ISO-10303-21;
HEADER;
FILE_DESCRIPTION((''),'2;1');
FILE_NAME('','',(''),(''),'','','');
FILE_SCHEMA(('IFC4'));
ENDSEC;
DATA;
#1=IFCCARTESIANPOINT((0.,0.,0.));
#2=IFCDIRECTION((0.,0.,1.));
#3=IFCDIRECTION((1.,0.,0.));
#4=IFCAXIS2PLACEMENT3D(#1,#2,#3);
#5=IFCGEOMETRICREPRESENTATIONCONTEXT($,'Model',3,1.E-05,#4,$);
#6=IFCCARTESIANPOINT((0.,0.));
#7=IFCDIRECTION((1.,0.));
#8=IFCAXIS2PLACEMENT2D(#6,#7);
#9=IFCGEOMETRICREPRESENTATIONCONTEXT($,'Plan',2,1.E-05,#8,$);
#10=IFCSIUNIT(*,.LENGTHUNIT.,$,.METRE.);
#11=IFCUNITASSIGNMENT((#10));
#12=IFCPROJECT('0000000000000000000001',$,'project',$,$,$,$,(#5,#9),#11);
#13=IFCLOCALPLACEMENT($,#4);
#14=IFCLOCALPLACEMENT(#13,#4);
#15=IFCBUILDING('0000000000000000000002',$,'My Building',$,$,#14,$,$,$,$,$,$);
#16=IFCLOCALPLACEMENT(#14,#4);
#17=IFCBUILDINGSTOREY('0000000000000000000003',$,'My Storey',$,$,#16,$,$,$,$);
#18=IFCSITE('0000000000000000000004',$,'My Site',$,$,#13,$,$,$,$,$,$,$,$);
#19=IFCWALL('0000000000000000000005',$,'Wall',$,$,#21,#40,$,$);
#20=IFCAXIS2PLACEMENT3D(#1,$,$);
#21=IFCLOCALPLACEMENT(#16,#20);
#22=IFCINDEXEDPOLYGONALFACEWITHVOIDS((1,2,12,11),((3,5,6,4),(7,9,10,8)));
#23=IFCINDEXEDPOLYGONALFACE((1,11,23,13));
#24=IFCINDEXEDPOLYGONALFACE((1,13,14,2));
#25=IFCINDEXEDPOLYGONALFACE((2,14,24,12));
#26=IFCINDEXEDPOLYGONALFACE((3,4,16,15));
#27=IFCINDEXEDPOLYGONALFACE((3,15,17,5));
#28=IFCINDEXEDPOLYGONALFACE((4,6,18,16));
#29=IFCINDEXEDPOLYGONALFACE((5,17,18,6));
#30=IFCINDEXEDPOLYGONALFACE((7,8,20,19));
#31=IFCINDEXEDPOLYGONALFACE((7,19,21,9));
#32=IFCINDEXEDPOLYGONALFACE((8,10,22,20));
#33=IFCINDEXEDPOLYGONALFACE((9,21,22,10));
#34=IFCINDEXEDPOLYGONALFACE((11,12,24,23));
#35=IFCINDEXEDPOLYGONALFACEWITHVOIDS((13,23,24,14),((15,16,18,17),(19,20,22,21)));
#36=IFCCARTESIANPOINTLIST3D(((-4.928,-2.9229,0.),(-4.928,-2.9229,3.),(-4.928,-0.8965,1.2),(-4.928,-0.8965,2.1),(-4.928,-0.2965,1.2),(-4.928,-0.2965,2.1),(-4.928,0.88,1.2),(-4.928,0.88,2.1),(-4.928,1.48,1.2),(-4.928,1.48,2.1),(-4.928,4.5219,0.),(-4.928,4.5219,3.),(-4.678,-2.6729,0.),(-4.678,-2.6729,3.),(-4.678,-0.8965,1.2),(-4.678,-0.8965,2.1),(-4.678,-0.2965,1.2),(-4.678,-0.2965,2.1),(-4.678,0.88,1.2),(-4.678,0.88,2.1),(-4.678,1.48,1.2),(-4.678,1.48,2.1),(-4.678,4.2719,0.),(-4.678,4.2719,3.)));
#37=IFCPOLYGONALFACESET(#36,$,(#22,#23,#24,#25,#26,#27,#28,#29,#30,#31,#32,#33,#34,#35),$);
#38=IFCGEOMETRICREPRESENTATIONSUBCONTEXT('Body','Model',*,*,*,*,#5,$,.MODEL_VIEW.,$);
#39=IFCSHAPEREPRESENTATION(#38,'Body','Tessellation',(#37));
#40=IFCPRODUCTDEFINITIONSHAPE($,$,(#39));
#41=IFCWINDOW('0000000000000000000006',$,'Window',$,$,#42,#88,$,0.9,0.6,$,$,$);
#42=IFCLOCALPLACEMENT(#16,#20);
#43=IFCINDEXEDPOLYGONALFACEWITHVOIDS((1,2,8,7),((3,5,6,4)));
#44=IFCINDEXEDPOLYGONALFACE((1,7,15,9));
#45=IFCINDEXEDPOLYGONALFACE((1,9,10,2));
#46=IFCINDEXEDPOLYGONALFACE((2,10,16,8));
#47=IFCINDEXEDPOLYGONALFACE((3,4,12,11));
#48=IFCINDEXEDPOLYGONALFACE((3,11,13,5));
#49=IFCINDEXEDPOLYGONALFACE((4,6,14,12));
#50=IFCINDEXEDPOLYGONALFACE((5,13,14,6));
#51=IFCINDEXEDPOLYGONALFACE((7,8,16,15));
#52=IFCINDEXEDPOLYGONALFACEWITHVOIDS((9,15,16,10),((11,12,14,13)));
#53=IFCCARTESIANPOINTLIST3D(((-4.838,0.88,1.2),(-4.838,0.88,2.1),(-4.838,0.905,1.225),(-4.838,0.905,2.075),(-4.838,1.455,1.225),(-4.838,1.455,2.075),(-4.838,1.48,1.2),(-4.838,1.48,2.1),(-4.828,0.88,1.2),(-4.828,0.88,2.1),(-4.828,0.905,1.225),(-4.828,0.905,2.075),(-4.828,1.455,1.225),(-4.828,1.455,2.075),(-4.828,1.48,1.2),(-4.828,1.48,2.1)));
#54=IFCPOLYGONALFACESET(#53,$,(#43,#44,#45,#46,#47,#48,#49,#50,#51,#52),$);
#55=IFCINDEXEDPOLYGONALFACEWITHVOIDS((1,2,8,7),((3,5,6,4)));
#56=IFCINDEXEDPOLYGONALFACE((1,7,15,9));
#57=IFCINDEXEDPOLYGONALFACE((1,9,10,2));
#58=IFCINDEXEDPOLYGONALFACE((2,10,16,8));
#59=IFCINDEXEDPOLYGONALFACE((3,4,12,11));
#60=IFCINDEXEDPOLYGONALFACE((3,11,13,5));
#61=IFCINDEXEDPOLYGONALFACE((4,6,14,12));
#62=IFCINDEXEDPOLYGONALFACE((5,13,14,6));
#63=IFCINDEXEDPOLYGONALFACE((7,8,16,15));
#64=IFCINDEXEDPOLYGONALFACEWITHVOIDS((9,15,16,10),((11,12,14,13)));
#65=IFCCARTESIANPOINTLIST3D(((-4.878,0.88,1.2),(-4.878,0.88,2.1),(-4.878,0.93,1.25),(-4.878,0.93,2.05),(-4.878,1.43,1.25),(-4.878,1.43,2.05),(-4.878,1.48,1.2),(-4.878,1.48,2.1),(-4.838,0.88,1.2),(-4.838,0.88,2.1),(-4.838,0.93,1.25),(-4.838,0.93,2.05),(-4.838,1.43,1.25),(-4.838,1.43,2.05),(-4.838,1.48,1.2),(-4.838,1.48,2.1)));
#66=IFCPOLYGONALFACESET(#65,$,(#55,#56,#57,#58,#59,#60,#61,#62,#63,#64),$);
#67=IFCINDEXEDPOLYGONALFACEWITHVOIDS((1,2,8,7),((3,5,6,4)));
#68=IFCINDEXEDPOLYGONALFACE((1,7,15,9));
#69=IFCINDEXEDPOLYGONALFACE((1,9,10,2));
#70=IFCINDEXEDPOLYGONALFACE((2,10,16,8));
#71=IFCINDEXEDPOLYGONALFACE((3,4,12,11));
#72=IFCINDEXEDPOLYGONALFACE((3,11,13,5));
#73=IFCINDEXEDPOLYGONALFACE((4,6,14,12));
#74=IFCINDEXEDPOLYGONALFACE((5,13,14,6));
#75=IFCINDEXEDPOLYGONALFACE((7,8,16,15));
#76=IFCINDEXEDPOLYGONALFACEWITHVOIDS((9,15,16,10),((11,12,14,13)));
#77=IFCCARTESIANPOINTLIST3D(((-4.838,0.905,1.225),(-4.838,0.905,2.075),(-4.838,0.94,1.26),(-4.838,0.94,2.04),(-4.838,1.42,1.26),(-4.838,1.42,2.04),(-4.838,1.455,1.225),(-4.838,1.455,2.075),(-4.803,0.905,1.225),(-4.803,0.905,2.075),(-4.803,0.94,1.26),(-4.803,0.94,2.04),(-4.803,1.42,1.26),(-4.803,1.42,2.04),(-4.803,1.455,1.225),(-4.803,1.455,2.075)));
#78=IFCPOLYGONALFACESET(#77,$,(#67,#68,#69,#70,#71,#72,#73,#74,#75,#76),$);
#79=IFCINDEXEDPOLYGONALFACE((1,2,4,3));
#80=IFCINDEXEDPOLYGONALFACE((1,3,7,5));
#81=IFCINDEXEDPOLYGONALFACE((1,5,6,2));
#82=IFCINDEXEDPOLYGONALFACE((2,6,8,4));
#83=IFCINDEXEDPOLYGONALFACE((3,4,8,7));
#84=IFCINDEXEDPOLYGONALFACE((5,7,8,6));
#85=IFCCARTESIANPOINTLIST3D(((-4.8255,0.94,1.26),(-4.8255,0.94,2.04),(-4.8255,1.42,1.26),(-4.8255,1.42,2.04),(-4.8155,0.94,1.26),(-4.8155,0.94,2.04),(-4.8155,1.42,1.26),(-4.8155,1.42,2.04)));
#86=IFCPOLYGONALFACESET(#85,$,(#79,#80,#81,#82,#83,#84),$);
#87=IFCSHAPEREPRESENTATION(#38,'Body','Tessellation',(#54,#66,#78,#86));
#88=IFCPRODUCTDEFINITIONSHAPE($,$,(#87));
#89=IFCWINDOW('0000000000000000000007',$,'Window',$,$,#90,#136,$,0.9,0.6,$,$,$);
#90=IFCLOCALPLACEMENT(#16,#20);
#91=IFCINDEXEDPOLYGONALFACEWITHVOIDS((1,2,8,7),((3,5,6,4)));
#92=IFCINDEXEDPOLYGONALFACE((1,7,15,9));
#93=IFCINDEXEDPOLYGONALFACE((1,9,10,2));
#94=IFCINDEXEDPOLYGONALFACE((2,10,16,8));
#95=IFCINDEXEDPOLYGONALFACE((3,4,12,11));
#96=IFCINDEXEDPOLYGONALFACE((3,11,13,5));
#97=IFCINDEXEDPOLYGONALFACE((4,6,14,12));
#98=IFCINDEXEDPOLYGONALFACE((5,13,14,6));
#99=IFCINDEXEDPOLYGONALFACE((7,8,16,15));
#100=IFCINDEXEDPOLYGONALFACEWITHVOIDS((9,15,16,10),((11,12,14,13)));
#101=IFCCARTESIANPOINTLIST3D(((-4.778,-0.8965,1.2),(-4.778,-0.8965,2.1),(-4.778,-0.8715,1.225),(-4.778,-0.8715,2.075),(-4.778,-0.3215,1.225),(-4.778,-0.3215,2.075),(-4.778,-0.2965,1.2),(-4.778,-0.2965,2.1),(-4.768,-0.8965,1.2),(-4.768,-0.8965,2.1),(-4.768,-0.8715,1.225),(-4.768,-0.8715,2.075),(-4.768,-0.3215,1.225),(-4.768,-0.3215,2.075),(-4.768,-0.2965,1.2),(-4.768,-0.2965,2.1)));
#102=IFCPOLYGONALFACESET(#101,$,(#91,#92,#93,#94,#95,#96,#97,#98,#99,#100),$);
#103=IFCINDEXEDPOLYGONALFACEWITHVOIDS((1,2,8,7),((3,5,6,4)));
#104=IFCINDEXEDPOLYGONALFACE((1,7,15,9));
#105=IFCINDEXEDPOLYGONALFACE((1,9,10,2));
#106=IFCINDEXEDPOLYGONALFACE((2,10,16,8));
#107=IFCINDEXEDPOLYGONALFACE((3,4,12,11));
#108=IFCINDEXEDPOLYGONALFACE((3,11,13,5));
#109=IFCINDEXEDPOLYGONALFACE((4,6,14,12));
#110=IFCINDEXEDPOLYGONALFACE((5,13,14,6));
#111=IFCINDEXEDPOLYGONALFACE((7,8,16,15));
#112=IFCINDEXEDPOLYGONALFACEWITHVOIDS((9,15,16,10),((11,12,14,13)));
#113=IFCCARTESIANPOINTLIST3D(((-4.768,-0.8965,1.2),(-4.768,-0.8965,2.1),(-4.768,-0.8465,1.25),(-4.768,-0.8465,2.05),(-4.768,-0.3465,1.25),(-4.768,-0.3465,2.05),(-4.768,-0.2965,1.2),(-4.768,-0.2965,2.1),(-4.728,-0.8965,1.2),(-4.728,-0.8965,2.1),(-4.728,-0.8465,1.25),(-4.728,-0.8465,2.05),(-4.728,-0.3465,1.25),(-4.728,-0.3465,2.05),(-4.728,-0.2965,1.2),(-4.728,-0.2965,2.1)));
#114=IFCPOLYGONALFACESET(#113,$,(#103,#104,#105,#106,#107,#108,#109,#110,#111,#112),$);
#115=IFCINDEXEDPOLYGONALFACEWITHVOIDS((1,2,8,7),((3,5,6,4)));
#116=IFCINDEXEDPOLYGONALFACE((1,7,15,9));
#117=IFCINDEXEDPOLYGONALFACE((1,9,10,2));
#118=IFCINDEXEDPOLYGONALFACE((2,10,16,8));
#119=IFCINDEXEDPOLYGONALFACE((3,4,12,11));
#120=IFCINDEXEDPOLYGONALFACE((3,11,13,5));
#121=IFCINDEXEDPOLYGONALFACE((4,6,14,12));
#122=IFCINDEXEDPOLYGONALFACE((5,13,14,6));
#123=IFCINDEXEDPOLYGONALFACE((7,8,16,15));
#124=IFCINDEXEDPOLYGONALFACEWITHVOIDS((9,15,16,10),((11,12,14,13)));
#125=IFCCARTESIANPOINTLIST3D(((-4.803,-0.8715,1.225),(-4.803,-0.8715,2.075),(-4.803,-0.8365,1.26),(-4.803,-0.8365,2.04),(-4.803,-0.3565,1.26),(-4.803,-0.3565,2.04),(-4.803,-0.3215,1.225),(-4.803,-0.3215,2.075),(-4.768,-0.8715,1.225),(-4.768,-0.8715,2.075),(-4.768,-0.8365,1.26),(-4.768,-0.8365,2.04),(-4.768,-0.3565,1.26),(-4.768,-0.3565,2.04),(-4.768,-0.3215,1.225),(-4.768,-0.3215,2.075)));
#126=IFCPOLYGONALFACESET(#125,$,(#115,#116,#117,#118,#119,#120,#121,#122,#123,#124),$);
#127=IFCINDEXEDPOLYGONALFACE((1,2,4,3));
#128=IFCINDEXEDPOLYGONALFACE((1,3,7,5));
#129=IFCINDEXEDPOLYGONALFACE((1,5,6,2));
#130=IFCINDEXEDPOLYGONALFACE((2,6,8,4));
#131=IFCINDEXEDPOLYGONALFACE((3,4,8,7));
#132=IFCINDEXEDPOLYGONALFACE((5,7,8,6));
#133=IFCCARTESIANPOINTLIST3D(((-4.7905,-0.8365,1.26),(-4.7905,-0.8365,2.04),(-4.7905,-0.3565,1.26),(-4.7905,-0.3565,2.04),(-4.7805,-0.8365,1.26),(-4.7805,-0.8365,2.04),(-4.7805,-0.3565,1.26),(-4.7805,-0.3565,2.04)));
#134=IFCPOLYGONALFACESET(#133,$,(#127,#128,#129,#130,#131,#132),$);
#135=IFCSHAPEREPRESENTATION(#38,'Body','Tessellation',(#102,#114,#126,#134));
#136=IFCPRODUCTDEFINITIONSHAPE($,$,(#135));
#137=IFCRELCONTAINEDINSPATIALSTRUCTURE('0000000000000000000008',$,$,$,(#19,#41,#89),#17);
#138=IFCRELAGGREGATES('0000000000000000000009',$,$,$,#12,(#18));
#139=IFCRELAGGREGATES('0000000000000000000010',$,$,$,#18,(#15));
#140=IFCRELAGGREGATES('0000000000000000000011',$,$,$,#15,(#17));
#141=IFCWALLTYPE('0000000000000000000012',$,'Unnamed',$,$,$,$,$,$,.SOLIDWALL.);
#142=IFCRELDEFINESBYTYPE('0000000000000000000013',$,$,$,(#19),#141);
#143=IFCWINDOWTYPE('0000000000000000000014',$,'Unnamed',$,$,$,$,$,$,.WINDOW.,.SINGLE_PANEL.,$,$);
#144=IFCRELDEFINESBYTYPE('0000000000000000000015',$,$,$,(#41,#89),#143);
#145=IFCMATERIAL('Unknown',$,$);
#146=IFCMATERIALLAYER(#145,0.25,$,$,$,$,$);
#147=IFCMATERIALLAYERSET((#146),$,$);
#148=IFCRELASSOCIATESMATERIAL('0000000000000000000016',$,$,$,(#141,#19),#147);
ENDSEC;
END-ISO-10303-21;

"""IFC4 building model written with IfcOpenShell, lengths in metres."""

from ifc_helpers import new_model, entity, si_unit, frame, origin_with_axes, origin_2d_with_axis, place, context, subcontext, project, spatial, line, indexed_curve, outline, extrude, shape, source, transform, mapped, material, layer, layer_set, layer_usage, type_object, type_shapes, element, fill, save


model = new_model("IFC4")

# Units and contexts
model_context = context("Model", 3, precision=1e-05, world=origin_with_axes())
plan_context = context("Plan", 2, precision=1e-05, world=origin_2d_with_axis())
body_context_1 = subcontext(model_context, "Body", "Model", "MODEL_VIEW")
body_context_2 = subcontext(plan_context, "Body", "Plan", "PLAN_VIEW")
ifc_project = project(units=[si_unit("LENGTHUNIT", "METRE")], contexts=[model_context, plan_context])

# Site, building, storey
site_placement = place(None, origin_with_axes())
site = spatial("IfcSite", under=ifc_project, at=site_placement, Name="My Site")
building_placement = place(site_placement, origin_with_axes())
building = spatial("IfcBuilding", under=site, at=building_placement, Name="My Building")
storey_placement = place(building_placement, origin_with_axes())
storey = spatial("IfcBuildingStorey", under=building, at=storey_placement, Name="My Storey")

# Shared definitions
ifc_material = material(Name="Unknown")

# Wall, openings, windows
ifc_layer_1 = layer(ifc_material, 0.25)
ifc_layer_set_1 = layer_set([ifc_layer_1])
ifc_layer_usage_1 = layer_usage(ifc_layer_set_1, "AXIS2", "POSITIVE", 0.0)
wall_type = type_object("IfcWallType", Name="Unnamed", PredefinedType="SOLIDWALL", material=ifc_layer_set_1)
wall_1_placement = place(storey_placement, frame((-4.928, 4.2719, 0.0), z_axis=(0.0, 0.0, 1.0), x_axis=(0.0, -1.0, 0.0)))
wall_1 = element("IfcWall", 1, at=wall_1_placement, inside=storey, type_object=wall_type, material=ifc_layer_usage_1, Name="Wall", context=body_context_1, shape_type="SweptSolid", body=[
    extrude(outline(indexed_curve([(-0.25, 0.0), (0.0, 0.25), (6.9448, 0.25), (7.1948, 0.0)], segments=[line(1, 2, 3, 4, 1)])), origin_with_axes(), (0.0, 0.0, 1.0), 3.0),
])
shared_shape_1 = source(origin_with_axes(), body_context_1, "Body", "SweptSolid", [
    extrude(outline(indexed_curve([(0.0, 0.0), (0.6, 0.0), (0.6, 0.9), (0.0, 0.9)], segments=[line(1, 2, 3, 4, 1)])), frame((0.0, -0.6, 0.0), z_axis=(0.0, -1.0, 0.0), x_axis=(1.0, 0.0, 0.0)), (0.0, 0.0, -1.0), 1.2),
])
opening_1_placement = place(wall_1_placement, frame((2.7918, 0.0, 1.2), z_axis=(0.0, 0.0, 1.0), x_axis=(1.0, 0.0, 0.0)))
opening_1 = element("IfcOpeningElement", 2, at=opening_1_placement, cuts=wall_1, PredefinedType="OPENING", context=body_context_1, shape_type="MappedRepresentation", body=[
    mapped(shared_shape_1, transform((0.0, 0.0, 0.0), x_axis=(1.0, 0.0, 0.0), y_axis=(0.0, 1.0, 0.0), z_axis=(0.0, 0.0, 1.0), scale=1.0)),
])
opening_2_placement = place(wall_1_placement, frame((5.1683, 0.25, 1.2), z_axis=(0.0, 0.0, 1.0), x_axis=(-1.0, 0.0, 0.0)))
opening_2 = element("IfcOpeningElement", 3, at=opening_2_placement, cuts=wall_1, PredefinedType="OPENING", context=body_context_1, shape_type="MappedRepresentation", body=[
    mapped(shared_shape_1, transform((0.0, 0.0, 0.0), x_axis=(1.0, 0.0, 0.0), y_axis=(0.0, 1.0, 0.0), z_axis=(0.0, 0.0, 1.0), scale=1.0)),
])
window_type = type_object("IfcWindowType", Name="Unnamed", PartitioningType="SINGLE_PANEL", PredefinedType="WINDOW")
shared_shape_2 = source(origin_with_axes(), body_context_1, "Body", "SweptSolid", [
    extrude(outline(indexed_curve([(0.0, 0.0), (0.6, 0.0), (0.6, 0.9), (0.0, 0.9)], segments=[line(1, 2, 3, 4, 1)]), holes=[indexed_curve([(0.025, 0.025), (0.575, 0.025), (0.575, 0.875), (0.025, 0.875)], segments=[line(1, 2, 3, 4, 1)])]), frame((0.0, 0.09, 0.0), z_axis=(0.0, -1.0, 0.0), x_axis=(1.0, 0.0, 0.0)), (0.0, 0.0, -1.0), 0.01),
    extrude(outline(indexed_curve([(0.0, 0.0), (0.6, 0.0), (0.6, 0.9), (0.0, 0.9)], segments=[line(1, 2, 3, 4, 1)]), holes=[indexed_curve([(0.05, 0.05), (0.55, 0.05), (0.55, 0.85), (0.05, 0.85)], segments=[line(1, 2, 3, 4, 1)])]), frame((0.0, 0.05, 0.0), z_axis=(0.0, -1.0, 0.0), x_axis=(1.0, 0.0, 0.0)), (0.0, 0.0, -1.0), 0.04),
    extrude(outline(indexed_curve([(0.0, 0.0), (0.55, 0.0), (0.55, 0.85), (0.0, 0.85)], segments=[line(1, 2, 3, 4, 1)]), holes=[indexed_curve([(0.035, 0.035), (0.515, 0.035), (0.515, 0.815), (0.035, 0.815)], segments=[line(1, 2, 3, 4, 1)])]), frame((0.025, 0.09, 0.025), z_axis=(0.0, -1.0, 0.0), x_axis=(1.0, 0.0, 0.0)), (0.0, 0.0, -1.0), 0.035),
    extrude(outline(indexed_curve([(0.035, 0.035), (0.515, 0.035), (0.515, 0.815), (0.035, 0.815)], segments=[line(1, 2, 3, 4, 1)])), frame((0.025, 0.1025, 0.025), z_axis=(0.0, -1.0, 0.0), x_axis=(1.0, 0.0, 0.0)), (0.0, 0.0, -1.0), 0.01),
])
shared_shape_3 = source(origin_with_axes(), body_context_2, "Body", "Curve2D", [
    entity("IfcIndexedPolyCurve", entity("IfcCartesianPointList2D", [[0.05, 0.05], [0.55, 0.05]])),
    entity("IfcIndexedPolyCurve", entity("IfcCartesianPointList2D", [[0.0, 0.1], [0.025, 0.1], [0.025, 0.09], [0.05, 0.09], [0.05, 0.05], [0.0, 0.05]]), [entity("IfcLineIndex", [1, 2, 3, 4, 5, 6, 1])]),
    entity("IfcIndexedPolyCurve", entity("IfcCartesianPointList2D", [[0.6, 0.1], [0.575, 0.1], [0.575, 0.09], [0.55, 0.09], [0.55, 0.05], [0.6, 0.05]]), [entity("IfcLineIndex", [1, 2, 3, 4, 5, 6, 1])]),
    entity("IfcIndexedPolyCurve", entity("IfcCartesianPointList2D", [[0.025, 0.09], [0.06, 0.09], [0.06, 0.125], [0.025, 0.125]]), [entity("IfcLineIndex", [1, 2, 3, 4, 1])]),
    entity("IfcIndexedPolyCurve", entity("IfcCartesianPointList2D", [[0.575, 0.09], [0.54, 0.09], [0.54, 0.125], [0.575, 0.125]]), [entity("IfcLineIndex", [1, 2, 3, 4, 1])]),
    entity("IfcIndexedPolyCurve", entity("IfcCartesianPointList2D", [[0.06, 0.09], [0.54, 0.09]])),
    entity("IfcIndexedPolyCurve", entity("IfcCartesianPointList2D", [[0.06, 0.125], [0.54, 0.125]])),
    entity("IfcIndexedPolyCurve", entity("IfcCartesianPointList2D", [[0.06, 0.1075], [0.54, 0.1075]])),
])
type_shapes(window_type, [shared_shape_2, shared_shape_3])
window_1_placement = place(opening_1_placement, frame((0.0, 0.0, 0.0), z_axis=(0.0, 0.0, 1.0), x_axis=(1.0, 0.0, 0.0)))
window_1 = element("IfcWindow", 4, at=window_1_placement, inside=storey, type_object=window_type, Name="Window", OverallHeight=0.9, OverallWidth=0.6, shapes=[
    shape(body_context_1, "Body", "MappedRepresentation", [mapped(shared_shape_2, transform((0.0, 0.0, 0.0), x_axis=(1.0, 0.0, 0.0), y_axis=(0.0, 1.0, 0.0), z_axis=(0.0, 0.0, 1.0), scale=1.0))]),
    shape(body_context_2, "Body", "MappedRepresentation", [mapped(shared_shape_3, transform((0.0, 0.0, 0.0), x_axis=(1.0, 0.0, 0.0), y_axis=(0.0, 1.0, 0.0), z_axis=(0.0, 0.0, 1.0), scale=1.0))]),
])
fill(opening_1, window_1)
window_2_placement = place(opening_2_placement, frame((0.0, 0.0, 0.0), z_axis=(0.0, 0.0, 1.0), x_axis=(1.0, 0.0, 0.0)))
window_2 = element("IfcWindow", 5, at=window_2_placement, inside=storey, type_object=window_type, Name="Window", OverallHeight=0.9, OverallWidth=0.6, shapes=[
    shape(body_context_1, "Body", "MappedRepresentation", [mapped(shared_shape_2, transform((0.0, 0.0, 0.0), x_axis=(1.0, 0.0, 0.0), y_axis=(0.0, 1.0, 0.0), z_axis=(0.0, 0.0, 1.0), scale=1.0))]),
    shape(body_context_2, "Body", "MappedRepresentation", [mapped(shared_shape_3, transform((0.0, 0.0, 0.0), x_axis=(1.0, 0.0, 0.0), y_axis=(0.0, 1.0, 0.0), z_axis=(0.0, 0.0, 1.0), scale=1.0))]),
])
fill(opening_2, window_2)

save(model, "model.ifc")
